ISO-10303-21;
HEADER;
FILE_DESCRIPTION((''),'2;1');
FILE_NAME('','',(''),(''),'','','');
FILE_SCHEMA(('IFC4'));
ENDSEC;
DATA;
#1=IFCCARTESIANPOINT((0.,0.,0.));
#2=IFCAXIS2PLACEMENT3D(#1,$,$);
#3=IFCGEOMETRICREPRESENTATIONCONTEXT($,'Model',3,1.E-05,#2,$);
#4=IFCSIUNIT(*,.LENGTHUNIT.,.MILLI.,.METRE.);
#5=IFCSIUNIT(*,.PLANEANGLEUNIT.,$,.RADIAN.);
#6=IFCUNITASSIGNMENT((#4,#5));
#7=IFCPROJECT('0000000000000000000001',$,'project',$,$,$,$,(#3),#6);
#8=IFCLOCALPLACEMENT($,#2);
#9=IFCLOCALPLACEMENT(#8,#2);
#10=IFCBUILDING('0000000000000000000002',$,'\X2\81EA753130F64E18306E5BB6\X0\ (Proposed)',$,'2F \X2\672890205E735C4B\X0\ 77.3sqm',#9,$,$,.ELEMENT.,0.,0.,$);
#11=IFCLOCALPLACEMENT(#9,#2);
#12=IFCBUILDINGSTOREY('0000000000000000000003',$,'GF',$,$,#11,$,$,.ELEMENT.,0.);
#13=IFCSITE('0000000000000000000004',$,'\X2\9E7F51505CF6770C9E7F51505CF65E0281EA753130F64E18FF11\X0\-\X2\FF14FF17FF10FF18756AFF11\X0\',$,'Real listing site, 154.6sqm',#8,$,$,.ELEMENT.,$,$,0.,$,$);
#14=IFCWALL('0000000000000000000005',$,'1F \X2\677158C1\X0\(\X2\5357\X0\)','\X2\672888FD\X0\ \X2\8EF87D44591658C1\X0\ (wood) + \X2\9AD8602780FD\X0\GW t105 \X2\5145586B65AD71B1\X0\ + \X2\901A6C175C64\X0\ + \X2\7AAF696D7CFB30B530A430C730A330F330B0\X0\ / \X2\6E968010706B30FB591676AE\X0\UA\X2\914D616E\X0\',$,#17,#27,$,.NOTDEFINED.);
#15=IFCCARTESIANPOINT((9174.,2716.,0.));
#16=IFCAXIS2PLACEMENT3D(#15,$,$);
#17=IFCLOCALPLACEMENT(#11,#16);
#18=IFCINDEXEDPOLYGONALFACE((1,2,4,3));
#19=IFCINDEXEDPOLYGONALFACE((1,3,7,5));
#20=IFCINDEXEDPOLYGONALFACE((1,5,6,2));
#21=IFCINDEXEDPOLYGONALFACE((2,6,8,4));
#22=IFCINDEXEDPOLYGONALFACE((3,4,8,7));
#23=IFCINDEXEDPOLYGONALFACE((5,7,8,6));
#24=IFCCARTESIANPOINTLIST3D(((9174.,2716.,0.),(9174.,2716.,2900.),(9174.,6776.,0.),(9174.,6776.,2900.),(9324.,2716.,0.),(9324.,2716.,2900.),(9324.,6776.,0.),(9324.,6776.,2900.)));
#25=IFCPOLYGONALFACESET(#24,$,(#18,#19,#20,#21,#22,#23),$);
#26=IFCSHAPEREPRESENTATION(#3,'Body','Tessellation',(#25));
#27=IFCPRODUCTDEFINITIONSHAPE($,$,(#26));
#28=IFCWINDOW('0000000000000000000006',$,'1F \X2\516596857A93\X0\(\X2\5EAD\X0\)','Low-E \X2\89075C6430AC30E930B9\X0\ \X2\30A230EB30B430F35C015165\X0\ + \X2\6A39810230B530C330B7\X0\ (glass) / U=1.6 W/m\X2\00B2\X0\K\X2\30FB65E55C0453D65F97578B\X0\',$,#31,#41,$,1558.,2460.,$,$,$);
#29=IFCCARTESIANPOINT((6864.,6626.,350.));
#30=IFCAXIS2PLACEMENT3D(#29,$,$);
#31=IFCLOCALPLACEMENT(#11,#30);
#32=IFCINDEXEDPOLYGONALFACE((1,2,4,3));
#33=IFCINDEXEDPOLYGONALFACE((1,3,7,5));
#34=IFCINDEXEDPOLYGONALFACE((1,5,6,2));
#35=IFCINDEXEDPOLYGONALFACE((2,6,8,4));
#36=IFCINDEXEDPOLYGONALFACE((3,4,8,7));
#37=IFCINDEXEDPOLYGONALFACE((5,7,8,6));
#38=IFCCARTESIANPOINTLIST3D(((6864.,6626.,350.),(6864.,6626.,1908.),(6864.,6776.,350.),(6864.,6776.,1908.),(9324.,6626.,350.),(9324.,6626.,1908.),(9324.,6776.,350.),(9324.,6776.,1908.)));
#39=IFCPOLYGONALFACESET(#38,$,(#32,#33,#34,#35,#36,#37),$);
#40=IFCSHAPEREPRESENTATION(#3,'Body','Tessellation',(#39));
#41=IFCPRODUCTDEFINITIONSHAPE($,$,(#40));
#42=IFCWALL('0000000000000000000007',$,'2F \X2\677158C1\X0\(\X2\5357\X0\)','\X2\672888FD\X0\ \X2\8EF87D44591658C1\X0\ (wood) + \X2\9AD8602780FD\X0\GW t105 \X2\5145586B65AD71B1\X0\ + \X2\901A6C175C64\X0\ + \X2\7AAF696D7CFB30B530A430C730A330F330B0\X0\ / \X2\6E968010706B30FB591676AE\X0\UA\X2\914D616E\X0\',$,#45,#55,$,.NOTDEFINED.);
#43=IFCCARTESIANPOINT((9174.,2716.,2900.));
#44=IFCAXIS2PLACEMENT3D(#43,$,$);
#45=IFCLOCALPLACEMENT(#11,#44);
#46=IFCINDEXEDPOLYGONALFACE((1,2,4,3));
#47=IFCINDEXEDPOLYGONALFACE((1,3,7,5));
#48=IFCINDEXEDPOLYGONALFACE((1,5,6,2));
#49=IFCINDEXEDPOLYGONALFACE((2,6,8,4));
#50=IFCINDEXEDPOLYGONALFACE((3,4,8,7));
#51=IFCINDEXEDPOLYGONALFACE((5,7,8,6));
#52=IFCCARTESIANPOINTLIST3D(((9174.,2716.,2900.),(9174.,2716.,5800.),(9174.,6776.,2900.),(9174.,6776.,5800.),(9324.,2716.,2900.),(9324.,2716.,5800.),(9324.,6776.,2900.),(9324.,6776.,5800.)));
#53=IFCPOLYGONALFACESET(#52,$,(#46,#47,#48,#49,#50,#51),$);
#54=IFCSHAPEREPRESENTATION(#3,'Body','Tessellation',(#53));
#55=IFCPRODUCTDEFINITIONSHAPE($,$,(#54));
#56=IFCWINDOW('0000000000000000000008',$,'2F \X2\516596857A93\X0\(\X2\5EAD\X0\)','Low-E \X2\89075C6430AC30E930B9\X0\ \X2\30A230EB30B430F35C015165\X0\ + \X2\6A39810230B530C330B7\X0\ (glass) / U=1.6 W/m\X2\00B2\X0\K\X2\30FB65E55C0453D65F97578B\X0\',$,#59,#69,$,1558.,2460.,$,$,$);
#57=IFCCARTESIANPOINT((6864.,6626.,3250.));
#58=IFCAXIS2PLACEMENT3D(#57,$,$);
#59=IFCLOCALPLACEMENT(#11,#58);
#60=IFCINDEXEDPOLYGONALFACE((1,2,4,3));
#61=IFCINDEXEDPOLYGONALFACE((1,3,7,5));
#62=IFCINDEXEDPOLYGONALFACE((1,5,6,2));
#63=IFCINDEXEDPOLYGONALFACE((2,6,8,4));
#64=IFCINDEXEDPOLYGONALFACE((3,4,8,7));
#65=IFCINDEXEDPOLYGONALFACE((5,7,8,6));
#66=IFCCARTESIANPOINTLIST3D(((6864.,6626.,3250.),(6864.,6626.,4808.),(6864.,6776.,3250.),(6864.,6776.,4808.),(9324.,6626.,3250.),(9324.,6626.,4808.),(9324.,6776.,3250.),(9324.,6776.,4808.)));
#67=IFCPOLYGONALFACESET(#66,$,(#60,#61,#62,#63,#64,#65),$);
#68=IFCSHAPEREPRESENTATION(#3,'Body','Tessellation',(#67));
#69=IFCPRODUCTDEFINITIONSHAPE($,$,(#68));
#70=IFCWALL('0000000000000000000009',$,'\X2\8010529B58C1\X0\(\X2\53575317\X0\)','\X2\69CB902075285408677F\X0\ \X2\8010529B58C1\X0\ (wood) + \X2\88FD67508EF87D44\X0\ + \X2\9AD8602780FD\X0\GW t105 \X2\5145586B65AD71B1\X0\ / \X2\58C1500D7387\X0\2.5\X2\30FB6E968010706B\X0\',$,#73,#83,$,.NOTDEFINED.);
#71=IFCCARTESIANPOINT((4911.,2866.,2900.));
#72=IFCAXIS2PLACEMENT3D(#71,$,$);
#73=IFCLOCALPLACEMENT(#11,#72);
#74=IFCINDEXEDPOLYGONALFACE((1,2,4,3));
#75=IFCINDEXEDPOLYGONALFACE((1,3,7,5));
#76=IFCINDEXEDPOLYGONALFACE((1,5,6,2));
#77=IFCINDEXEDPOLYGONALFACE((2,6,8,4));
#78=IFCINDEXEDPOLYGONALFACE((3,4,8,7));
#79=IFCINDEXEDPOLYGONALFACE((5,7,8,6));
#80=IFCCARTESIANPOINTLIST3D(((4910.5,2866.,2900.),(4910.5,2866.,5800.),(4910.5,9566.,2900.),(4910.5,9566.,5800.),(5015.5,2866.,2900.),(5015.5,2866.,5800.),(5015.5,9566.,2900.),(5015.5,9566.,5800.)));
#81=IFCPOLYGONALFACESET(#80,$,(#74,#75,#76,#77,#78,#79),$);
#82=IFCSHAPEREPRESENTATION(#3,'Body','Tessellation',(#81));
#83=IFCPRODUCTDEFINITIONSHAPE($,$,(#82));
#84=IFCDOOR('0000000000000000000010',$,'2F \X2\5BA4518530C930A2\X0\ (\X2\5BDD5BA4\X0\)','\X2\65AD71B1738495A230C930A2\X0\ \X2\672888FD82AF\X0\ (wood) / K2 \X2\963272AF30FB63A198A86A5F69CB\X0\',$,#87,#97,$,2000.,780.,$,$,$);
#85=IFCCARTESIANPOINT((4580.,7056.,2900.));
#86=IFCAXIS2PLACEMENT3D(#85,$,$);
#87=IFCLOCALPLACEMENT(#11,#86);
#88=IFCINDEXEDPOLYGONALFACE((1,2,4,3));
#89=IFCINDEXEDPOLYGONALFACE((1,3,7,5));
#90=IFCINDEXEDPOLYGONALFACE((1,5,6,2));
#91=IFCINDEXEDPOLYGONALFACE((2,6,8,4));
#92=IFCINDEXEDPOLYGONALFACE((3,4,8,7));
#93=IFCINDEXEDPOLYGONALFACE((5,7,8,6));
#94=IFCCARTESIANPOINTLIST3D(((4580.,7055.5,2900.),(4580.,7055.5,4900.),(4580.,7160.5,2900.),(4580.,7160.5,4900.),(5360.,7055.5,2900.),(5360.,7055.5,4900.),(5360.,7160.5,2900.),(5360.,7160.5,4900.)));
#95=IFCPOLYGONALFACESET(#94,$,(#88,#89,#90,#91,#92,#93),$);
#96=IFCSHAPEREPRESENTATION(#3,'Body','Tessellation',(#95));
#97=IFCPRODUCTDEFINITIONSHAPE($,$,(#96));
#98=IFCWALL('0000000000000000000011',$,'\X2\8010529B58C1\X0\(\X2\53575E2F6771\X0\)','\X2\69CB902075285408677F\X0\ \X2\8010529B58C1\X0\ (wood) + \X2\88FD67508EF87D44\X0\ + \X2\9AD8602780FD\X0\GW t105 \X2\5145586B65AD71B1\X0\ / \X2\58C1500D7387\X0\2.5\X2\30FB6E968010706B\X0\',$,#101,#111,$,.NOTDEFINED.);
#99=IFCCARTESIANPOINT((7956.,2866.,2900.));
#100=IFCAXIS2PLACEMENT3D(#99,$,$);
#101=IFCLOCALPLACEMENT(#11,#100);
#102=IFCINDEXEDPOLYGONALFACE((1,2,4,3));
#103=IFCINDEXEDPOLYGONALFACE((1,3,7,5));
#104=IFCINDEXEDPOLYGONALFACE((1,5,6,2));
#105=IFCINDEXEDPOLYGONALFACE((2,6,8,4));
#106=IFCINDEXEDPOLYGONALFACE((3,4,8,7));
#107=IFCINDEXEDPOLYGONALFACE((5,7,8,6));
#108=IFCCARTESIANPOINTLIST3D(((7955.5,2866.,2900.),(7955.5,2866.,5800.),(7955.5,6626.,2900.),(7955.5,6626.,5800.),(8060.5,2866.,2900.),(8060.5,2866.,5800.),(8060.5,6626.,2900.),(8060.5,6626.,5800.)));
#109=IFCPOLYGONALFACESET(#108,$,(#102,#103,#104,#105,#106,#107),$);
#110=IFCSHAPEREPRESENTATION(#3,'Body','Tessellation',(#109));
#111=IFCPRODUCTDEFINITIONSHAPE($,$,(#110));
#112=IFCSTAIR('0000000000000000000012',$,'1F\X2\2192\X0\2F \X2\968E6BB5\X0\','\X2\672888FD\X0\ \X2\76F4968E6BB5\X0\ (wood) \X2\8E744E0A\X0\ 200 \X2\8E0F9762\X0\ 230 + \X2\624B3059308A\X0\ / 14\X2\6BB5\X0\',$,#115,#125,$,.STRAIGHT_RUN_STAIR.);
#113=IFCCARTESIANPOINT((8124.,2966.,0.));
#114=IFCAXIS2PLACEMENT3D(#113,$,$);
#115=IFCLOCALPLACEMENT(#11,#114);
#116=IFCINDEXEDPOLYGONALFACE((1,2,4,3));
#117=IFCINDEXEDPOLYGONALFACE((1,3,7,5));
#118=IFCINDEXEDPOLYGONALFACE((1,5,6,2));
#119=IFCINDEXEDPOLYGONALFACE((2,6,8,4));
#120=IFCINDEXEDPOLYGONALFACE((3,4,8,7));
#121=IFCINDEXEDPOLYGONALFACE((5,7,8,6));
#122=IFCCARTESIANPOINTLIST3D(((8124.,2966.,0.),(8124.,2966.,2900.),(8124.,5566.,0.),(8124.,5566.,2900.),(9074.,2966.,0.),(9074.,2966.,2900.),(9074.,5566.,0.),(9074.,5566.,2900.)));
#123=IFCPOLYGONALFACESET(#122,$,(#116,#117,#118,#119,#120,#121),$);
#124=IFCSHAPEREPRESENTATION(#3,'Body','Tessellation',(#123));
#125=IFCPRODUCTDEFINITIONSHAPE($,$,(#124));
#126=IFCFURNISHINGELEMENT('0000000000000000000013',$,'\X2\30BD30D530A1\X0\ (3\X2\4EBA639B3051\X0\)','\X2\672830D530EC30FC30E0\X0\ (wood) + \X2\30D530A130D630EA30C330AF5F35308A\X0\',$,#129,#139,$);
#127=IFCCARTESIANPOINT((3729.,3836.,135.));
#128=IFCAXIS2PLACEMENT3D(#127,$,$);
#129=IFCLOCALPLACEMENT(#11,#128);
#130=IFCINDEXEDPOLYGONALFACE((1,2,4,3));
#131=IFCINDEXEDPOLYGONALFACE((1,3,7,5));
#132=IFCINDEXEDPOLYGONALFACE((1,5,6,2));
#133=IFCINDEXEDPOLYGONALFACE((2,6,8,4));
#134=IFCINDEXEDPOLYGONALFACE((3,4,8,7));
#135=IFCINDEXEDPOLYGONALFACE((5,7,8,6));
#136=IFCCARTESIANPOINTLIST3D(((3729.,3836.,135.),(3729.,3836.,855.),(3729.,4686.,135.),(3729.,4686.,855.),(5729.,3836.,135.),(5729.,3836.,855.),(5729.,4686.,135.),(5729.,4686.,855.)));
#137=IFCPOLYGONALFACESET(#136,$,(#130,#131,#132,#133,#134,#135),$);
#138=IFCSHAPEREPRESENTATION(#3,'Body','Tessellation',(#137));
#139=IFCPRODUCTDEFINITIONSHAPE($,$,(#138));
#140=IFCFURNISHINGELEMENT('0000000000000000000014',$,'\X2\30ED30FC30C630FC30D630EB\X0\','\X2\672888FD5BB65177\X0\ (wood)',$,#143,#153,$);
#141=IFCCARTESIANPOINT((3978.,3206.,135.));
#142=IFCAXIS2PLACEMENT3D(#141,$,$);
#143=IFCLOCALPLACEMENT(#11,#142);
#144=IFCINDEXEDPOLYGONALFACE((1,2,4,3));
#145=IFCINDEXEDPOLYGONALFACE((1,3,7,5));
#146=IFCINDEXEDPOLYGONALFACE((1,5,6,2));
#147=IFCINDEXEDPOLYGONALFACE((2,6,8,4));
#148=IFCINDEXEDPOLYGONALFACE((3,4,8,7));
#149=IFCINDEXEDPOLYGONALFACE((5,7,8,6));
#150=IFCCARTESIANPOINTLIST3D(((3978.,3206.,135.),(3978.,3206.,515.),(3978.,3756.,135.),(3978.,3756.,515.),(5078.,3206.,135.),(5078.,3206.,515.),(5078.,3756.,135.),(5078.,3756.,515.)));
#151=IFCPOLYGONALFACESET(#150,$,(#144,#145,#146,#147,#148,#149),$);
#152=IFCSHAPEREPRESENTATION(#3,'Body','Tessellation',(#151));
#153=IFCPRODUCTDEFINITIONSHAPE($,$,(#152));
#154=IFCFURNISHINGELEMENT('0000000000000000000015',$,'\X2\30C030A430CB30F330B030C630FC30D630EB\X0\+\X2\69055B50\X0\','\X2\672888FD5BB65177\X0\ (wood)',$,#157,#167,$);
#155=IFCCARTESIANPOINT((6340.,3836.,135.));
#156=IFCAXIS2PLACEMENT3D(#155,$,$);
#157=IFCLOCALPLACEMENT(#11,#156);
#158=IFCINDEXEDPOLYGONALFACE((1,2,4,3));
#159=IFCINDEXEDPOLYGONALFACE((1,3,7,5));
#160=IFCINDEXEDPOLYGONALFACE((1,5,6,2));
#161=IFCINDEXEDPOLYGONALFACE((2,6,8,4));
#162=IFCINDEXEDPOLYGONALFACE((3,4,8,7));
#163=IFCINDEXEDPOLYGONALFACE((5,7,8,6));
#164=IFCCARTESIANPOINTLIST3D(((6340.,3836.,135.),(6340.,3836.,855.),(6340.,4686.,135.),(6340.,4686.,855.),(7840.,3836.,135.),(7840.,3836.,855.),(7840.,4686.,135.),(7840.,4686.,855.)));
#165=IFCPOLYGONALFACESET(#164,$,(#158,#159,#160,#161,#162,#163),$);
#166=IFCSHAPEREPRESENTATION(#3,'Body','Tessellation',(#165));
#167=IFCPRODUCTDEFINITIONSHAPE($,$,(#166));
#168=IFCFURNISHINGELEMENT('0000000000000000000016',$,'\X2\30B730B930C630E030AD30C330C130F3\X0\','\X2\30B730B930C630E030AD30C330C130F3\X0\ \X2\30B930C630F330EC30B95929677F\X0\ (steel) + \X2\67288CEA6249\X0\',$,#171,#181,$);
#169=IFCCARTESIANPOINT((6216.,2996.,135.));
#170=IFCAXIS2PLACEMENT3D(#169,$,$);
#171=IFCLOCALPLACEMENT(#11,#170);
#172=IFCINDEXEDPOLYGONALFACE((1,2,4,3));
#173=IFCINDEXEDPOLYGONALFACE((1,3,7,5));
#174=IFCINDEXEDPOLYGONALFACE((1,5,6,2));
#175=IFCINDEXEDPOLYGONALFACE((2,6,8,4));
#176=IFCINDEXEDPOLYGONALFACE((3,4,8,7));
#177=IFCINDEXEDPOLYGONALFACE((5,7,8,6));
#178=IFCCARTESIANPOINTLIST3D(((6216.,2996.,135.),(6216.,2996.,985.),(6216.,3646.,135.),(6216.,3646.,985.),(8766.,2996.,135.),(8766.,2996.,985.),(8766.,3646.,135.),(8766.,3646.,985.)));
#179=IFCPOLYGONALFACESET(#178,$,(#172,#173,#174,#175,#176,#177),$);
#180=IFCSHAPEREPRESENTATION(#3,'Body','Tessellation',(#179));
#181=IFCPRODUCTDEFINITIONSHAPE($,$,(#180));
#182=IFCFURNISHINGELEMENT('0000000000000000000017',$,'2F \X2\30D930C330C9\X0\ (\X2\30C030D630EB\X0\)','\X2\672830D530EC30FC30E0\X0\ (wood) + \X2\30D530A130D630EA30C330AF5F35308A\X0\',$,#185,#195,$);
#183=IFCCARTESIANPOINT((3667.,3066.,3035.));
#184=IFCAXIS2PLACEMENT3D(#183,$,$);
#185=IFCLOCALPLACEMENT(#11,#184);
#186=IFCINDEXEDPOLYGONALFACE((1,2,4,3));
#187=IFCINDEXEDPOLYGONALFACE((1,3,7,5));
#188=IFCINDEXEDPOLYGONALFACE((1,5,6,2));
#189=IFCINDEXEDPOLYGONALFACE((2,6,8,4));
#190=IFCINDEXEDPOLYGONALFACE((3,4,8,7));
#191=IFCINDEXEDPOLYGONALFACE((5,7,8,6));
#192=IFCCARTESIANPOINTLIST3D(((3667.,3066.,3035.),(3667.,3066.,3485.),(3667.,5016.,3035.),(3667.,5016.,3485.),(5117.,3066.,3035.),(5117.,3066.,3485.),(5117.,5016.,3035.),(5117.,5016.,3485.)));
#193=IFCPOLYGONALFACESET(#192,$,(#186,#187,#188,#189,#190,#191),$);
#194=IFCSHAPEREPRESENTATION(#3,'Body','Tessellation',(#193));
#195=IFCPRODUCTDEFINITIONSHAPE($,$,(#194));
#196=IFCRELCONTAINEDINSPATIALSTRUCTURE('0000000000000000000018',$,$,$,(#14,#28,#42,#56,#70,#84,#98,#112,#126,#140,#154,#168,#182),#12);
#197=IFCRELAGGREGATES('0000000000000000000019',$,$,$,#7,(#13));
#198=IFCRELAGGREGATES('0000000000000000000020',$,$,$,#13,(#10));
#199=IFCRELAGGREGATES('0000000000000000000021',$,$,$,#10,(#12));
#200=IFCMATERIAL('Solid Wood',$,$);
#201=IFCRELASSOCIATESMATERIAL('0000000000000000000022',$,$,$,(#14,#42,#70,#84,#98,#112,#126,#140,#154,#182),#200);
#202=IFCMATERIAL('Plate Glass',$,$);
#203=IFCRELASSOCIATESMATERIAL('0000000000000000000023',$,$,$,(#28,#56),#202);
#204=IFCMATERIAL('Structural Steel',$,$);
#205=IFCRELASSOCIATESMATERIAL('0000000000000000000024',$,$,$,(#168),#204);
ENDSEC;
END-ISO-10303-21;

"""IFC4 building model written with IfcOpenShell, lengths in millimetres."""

from ifc_helpers import new_model, si_unit, frame, frame_2d, origin, place, context, project, spatial, rectangle, extrude, material, element, fill, save


model = new_model("IFC4")

# Units and contexts
model_context = context("Model", 3, precision=1e-05, world=origin())
ifc_project = project(units=[si_unit("LENGTHUNIT", "METRE", prefix="MILLI"), si_unit("PLANEANGLEUNIT", "RADIAN")], contexts=[model_context])

# Site, building, storey
site_placement = place(None, origin())
site = spatial("IfcSite", under=ifc_project, at=site_placement, Name="鹿児島県鹿児島市自由ヶ丘１-４７０８番１", ObjectType="Real listing site, 154.6sqm", CompositionType="ELEMENT", RefElevation=0.0)
building_placement = place(site_placement, origin())
building = spatial("IfcBuilding", under=site, at=building_placement, Name="自由ヶ丘の家 (Proposed)", ObjectType="2F 木造平屋 77.3sqm", CompositionType="ELEMENT", ElevationOfRefHeight=0.0, ElevationOfTerrain=0.0)
storey_placement = place(building_placement, origin())
storey = spatial("IfcBuildingStorey", under=building, at=storey_placement, Name="GF", CompositionType="ELEMENT", Elevation=0.0)

# Wall, opening, window
ifc_material_1 = material(Name="Solid Wood")
wall_1_placement = place(storey_placement, frame((9174.0, 2716.0, 0.0)))
wall_1 = element("IfcWall", 1, at=wall_1_placement, inside=storey, material=ifc_material_1, Name="1F 東壁(南)", Description="木製 軸組外壁 (wood) + 高性能GW t105 充填断熱 + 通気層 + 窯業系サイディング / 準耐火・外皮UA配慮", PredefinedType="NOTDEFINED", context=model_context, shape_type="SweptSolid", body=[
    extrude(rectangle(XDim=150.0, YDim=4060.0, at=frame_2d((75.0, 2030.0))), frame((9174.0, 2716.0, 0.0)), (0.0, 0.0, 1.0), 2900.0),
])
opening_1_placement = place(storey_placement, frame((6864.0, 6626.0, 350.0)))
opening_1 = element("IfcOpeningElement", 2, at=opening_1_placement, cuts=wall_1, PredefinedType="NOTDEFINED", context=model_context, shape_type="SweptSolid", body=[
    extrude(rectangle(XDim=2460.0, YDim=150.0, at=frame_2d((1230.0, 75.0))), frame((6864.0, 6626.0, 350.0)), (0.0, 0.0, 1.0), 1558.0),
])
ifc_material_2 = material(Name="Plate Glass")
window_1_placement = place(storey_placement, frame((6864.0, 6626.0, 350.0)))
window_1 = element("IfcWindow", 3, at=window_1_placement, inside=storey, material=ifc_material_2, Name="1F 入隅窓(庭)", Description="Low-E 複層ガラス アルゴン封入 + 樹脂サッシ (glass) / U=1.6 W/m²K・日射取得型", OverallHeight=1558.0, OverallWidth=2460.0, context=model_context, shape_type="SweptSolid", body=[
    extrude(rectangle(XDim=2460.0, YDim=150.0, at=frame_2d((1230.0, 75.0))), frame((6864.0, 6626.0, 350.0)), (0.0, 0.0, 1.0), 1558.0),
])
fill(opening_1, window_1)

# Wall, opening, window
wall_2_placement = place(storey_placement, frame((9174.0, 2716.0, 2900.0)))
wall_2 = element("IfcWall", 4, at=wall_2_placement, inside=storey, material=ifc_material_1, Name="2F 東壁(南)", Description="木製 軸組外壁 (wood) + 高性能GW t105 充填断熱 + 通気層 + 窯業系サイディング / 準耐火・外皮UA配慮", PredefinedType="NOTDEFINED", context=model_context, shape_type="SweptSolid", body=[
    extrude(rectangle(XDim=150.0, YDim=4060.0, at=frame_2d((75.0, 2030.0))), frame((9174.0, 2716.0, 2900.0)), (0.0, 0.0, 1.0), 2900.0),
])
opening_2_placement = place(storey_placement, frame((6864.0, 6626.0, 3250.0)))
opening_2 = element("IfcOpeningElement", 5, at=opening_2_placement, cuts=wall_2, PredefinedType="NOTDEFINED", context=model_context, shape_type="SweptSolid", body=[
    extrude(rectangle(XDim=2460.0, YDim=150.0, at=frame_2d((1230.0, 75.0))), frame((6864.0, 6626.0, 3250.0)), (0.0, 0.0, 1.0), 1558.0),
])
window_2_placement = place(storey_placement, frame((6864.0, 6626.0, 3250.0)))
window_2 = element("IfcWindow", 6, at=window_2_placement, inside=storey, material=ifc_material_2, Name="2F 入隅窓(庭)", Description="Low-E 複層ガラス アルゴン封入 + 樹脂サッシ (glass) / U=1.6 W/m²K・日射取得型", OverallHeight=1558.0, OverallWidth=2460.0, context=model_context, shape_type="SweptSolid", body=[
    extrude(rectangle(XDim=2460.0, YDim=150.0, at=frame_2d((1230.0, 75.0))), frame((6864.0, 6626.0, 3250.0)), (0.0, 0.0, 1.0), 1558.0),
])
fill(opening_2, window_2)

# Wall, opening, door
wall_3_placement = place(storey_placement, frame((4911.0, 2866.0, 2900.0)))
wall_3 = element("IfcWall", 7, at=wall_3_placement, inside=storey, material=ifc_material_1, Name="耐力壁(南北)", Description="構造用合板 耐力壁 (wood) + 製材軸組 + 高性能GW t105 充填断熱 / 壁倍率2.5・準耐火", PredefinedType="NOTDEFINED", context=model_context, shape_type="SweptSolid", body=[
    extrude(rectangle(XDim=105.0, YDim=6700.0, at=frame_2d((52.0, 3350.0))), frame((4911.0, 2866.0, 2900.0)), (0.0, 0.0, 1.0), 2900.0),
])
opening_3_placement = place(storey_placement, frame((4580.0, 7056.0, 2900.0)))
opening_3 = element("IfcOpeningElement", 8, at=opening_3_placement, cuts=wall_3, PredefinedType="NOTDEFINED", context=model_context, shape_type="SweptSolid", body=[
    extrude(rectangle(XDim=780.0, YDim=105.0, at=frame_2d((390.0, 52.0))), frame((4580.0, 7056.0, 2900.0)), (0.0, 0.0, 1.0), 2000.0),
])
door_1_placement = place(storey_placement, frame((4580.0, 7056.0, 2900.0)))
door_1 = element("IfcDoor", 9, at=door_1_placement, inside=storey, material=ifc_material_1, Name="2F 室内ドア (寝室)", Description="断熱玄関ドア 木製芯 (wood) / K2 防犯・採風機構", OverallHeight=2000.0, OverallWidth=780.0, context=model_context, shape_type="SweptSolid", body=[
    extrude(rectangle(XDim=780.0, YDim=105.0, at=frame_2d((390.0, 52.0))), frame((4580.0, 7056.0, 2900.0)), (0.0, 0.0, 1.0), 2000.0),
])
fill(opening_3, door_1)

# Wall
wall_4_placement = place(storey_placement, frame((7956.0, 2866.0, 2900.0)))
element("IfcWall", 10, at=wall_4_placement, inside=storey, material=ifc_material_1, Name="耐力壁(南帯東)", Description="構造用合板 耐力壁 (wood) + 製材軸組 + 高性能GW t105 充填断熱 / 壁倍率2.5・準耐火", PredefinedType="NOTDEFINED", context=model_context, shape_type="SweptSolid", body=[
    extrude(rectangle(XDim=105.0, YDim=3760.0, at=frame_2d((52.0, 1880.0))), frame((7956.0, 2866.0, 2900.0)), (0.0, 0.0, 1.0), 2900.0),
])

# Stair
stair_placement = place(storey_placement, frame((8124.0, 2966.0, 0.0)))
element("IfcStair", 11, at=stair_placement, inside=storey, material=ifc_material_1, Name="1F→2F 階段", Description="木製 直階段 (wood) 蹴上 200 踏面 230 + 手すり / 14段", PredefinedType="STRAIGHT_RUN_STAIR", context=model_context, shape_type="SweptSolid", body=[
    extrude(rectangle(XDim=950.0, YDim=2600.0, at=frame_2d((475.0, 1300.0))), frame((8124.0, 2966.0, 0.0)), (0.0, 0.0, 1.0), 2900.0),
])

# Furnishing elements
furnishing_1_placement = place(storey_placement, frame((3729.0, 3836.0, 135.0)))
element("IfcFurnishingElement", 12, at=furnishing_1_placement, inside=storey, material=ifc_material_1, Name="ソファ (3人掛け)", Description="木フレーム (wood) + ファブリック張り", context=model_context, shape_type="SweptSolid", body=[
    extrude(rectangle(XDim=2000.0, YDim=850.0, at=frame_2d((1000.0, 425.0))), frame((3729.0, 3836.0, 135.0)), (0.0, 0.0, 1.0), 720.0),
])
furnishing_2_placement = place(storey_placement, frame((3978.0, 3206.0, 135.0)))
element("IfcFurnishingElement", 13, at=furnishing_2_placement, inside=storey, material=ifc_material_1, Name="ローテーブル", Description="木製家具 (wood)", context=model_context, shape_type="SweptSolid", body=[
    extrude(rectangle(XDim=1100.0, YDim=550.0, at=frame_2d((550.0, 275.0))), frame((3978.0, 3206.0, 135.0)), (0.0, 0.0, 1.0), 380.0),
])
furnishing_3_placement = place(storey_placement, frame((6340.0, 3836.0, 135.0)))
element("IfcFurnishingElement", 14, at=furnishing_3_placement, inside=storey, material=ifc_material_1, Name="ダイニングテーブル+椅子", Description="木製家具 (wood)", context=model_context, shape_type="SweptSolid", body=[
    extrude(rectangle(XDim=1500.0, YDim=850.0, at=frame_2d((750.0, 425.0))), frame((6340.0, 3836.0, 135.0)), (0.0, 0.0, 1.0), 720.0),
])
ifc_material_3 = material(Name="Structural Steel")
furnishing_4_placement = place(storey_placement, frame((6216.0, 2996.0, 135.0)))
element("IfcFurnishingElement", 15, at=furnishing_4_placement, inside=storey, material=ifc_material_3, Name="システムキッチン", Description="システムキッチン ステンレス天板 (steel) + 木質扉", context=model_context, shape_type="SweptSolid", body=[
    extrude(rectangle(XDim=2550.0, YDim=650.0, at=frame_2d((1275.0, 325.0))), frame((6216.0, 2996.0, 135.0)), (0.0, 0.0, 1.0), 850.0),
])
furnishing_5_placement = place(storey_placement, frame((3667.0, 3066.0, 3035.0)))
element("IfcFurnishingElement", 16, at=furnishing_5_placement, inside=storey, material=ifc_material_1, Name="2F ベッド (ダブル)", Description="木フレーム (wood) + ファブリック張り", context=model_context, shape_type="SweptSolid", body=[
    extrude(rectangle(XDim=1450.0, YDim=1950.0, at=frame_2d((725.0, 975.0))), frame((3667.0, 3066.0, 3035.0)), (0.0, 0.0, 1.0), 450.0),
])

save(model, "model.ifc")
